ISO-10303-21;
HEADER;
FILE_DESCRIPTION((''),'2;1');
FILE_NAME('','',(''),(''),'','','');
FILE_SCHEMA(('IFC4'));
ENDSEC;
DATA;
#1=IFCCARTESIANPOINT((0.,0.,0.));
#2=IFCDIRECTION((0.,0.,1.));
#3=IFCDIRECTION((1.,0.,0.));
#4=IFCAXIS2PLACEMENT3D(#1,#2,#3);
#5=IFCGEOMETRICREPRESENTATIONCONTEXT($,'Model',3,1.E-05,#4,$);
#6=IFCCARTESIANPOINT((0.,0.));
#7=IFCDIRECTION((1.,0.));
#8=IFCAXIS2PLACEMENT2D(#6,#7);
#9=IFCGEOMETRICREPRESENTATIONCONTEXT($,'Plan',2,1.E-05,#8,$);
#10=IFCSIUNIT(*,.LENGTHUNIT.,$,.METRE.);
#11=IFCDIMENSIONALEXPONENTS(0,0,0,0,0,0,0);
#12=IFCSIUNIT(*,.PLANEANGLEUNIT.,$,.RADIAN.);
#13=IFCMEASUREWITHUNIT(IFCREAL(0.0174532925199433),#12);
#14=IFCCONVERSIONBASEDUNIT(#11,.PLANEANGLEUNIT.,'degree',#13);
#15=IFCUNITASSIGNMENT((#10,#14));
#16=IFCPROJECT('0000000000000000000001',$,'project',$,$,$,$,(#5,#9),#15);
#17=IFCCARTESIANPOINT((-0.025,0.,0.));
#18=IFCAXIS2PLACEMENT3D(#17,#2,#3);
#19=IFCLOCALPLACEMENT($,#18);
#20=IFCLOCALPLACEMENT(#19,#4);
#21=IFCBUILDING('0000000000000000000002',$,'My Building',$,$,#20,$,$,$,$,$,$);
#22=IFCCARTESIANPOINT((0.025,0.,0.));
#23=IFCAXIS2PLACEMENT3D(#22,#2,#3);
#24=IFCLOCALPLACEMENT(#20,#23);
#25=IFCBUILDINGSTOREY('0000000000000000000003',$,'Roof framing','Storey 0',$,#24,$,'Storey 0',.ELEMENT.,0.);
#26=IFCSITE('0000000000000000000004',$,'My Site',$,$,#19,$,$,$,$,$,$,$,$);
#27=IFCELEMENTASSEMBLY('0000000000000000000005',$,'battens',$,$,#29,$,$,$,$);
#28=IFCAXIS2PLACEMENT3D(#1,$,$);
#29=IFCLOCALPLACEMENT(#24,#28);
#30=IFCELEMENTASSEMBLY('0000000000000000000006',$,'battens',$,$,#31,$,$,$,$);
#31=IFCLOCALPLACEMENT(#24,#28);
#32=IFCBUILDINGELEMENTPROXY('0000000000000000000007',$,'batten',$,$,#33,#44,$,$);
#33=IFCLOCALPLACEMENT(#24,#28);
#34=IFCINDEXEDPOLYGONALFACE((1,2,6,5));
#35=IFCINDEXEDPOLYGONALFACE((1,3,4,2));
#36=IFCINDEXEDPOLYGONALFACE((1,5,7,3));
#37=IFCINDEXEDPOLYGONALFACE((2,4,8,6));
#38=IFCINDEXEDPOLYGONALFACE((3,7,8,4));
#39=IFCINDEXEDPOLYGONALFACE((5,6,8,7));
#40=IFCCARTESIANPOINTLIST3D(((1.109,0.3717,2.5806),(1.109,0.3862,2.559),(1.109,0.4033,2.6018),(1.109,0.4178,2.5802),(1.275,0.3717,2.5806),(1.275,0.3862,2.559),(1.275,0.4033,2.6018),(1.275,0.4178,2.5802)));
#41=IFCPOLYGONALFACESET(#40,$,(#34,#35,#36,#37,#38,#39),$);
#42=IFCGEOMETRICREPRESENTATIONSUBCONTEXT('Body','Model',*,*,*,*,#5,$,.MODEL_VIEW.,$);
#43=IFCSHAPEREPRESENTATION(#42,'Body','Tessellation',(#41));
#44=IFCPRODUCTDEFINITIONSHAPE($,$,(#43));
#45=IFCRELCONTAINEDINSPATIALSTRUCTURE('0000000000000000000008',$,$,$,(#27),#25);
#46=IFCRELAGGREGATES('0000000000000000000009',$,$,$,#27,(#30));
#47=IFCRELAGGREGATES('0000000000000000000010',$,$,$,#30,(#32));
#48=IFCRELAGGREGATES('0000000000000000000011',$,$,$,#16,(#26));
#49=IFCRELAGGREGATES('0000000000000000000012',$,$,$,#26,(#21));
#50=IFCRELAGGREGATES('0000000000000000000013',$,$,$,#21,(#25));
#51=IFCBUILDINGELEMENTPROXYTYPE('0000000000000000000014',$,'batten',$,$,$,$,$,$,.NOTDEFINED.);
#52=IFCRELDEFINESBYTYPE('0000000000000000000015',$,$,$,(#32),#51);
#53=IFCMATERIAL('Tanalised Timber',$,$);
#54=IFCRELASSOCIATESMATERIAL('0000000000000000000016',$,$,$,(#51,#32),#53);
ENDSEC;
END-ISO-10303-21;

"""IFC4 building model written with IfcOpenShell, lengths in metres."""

from ifc_helpers import new_model, entity, si_unit, converted_unit, frame, frame_2d, origin_with_axes, origin_2d_with_axis, place, context, subcontext, project, spatial, rectangle, extrude, material, material_profile, profile_set, profile_usage, type_object, element, aggregate, save


model = new_model("IFC4")

# Units and contexts
model_context = context("Model", 3, precision=1e-05, world=origin_with_axes())
plan_context = context("Plan", 2, precision=1e-05, world=origin_2d_with_axis())
body_context = subcontext(model_context, "Body", "Model", "MODEL_VIEW")
ifc_project = project(units=[si_unit("LENGTHUNIT", "METRE"), converted_unit("PLANEANGLEUNIT", "degree", entity("IfcReal", 0.0174532925199433), si_unit("PLANEANGLEUNIT", "RADIAN"), dimensions=[0, 0, 0, 0, 0, 0, 0])], contexts=[model_context, plan_context])

# Site, building, storey
site_placement = place(None, frame((-0.025, 0.0, 0.0), z_axis=(0.0, 0.0, 1.0), x_axis=(1.0, 0.0, 0.0)))
site = spatial("IfcSite", under=ifc_project, at=site_placement, Name="My Site")
building_placement = place(site_placement, origin_with_axes())
building = spatial("IfcBuilding", under=site, at=building_placement, Name="My Building")
storey_placement = place(building_placement, frame((0.025, 0.0, 0.0), z_axis=(0.0, 0.0, 1.0), x_axis=(1.0, 0.0, 0.0)))
storey = spatial("IfcBuildingStorey", under=building, at=storey_placement, Name="Roof framing", Description="Storey 0", LongName="Storey 0", CompositionType="ELEMENT", Elevation=0.0)

# Element assemblies, building element proxy
assembly_1_placement = place(storey_placement, origin_with_axes())
assembly_1 = element("IfcElementAssembly", 1, at=assembly_1_placement, inside=storey, Name="battens")
ifc_material_1 = material(Name="Tanalised Timber")
ifc_material_profile_1 = material_profile(ifc_material_1, rectangle(XDim=0.038, YDim=0.026, at=frame_2d((0.0, 0.083), x_axis=(1.0, 0.0))))
ifc_profile_set_1 = profile_set([ifc_material_profile_1])
building_element_proxy_type = type_object("IfcBuildingElementProxyType", Name="batten", PredefinedType="NOTDEFINED", material=ifc_profile_set_1)
assembly_2_placement = place(assembly_1_placement, frame((1.275, 0.275, 2.4), z_axis=(0.0, -0.557621, 0.830095), x_axis=(1.0, 0.0, 0.0)))
assembly_2 = element("IfcElementAssembly", 2, at=assembly_2_placement, Name="battens")
aggregate(assembly_1, [assembly_2])
ifc_profile_usage_1 = profile_usage(ifc_profile_set_1)
proxy_1_placement = place(assembly_2_placement, frame((0.0, 0.2, 0.0), z_axis=(-1.0, 0.0, 0.0), x_axis=(0.0, -1.0, 0.0)))
proxy_1 = element("IfcBuildingElementProxy", 3, at=proxy_1_placement, type_object=building_element_proxy_type, material=ifc_profile_usage_1, Name="batten", context=body_context, shape_type="SweptSolid", body=[
    extrude(rectangle(XDim=0.038, YDim=0.026, at=frame_2d((0.0, 0.083), x_axis=(1.0, 0.0))), origin_with_axes(), (0.0, 0.0, 1.0), 0.166),
])
aggregate(assembly_2, [proxy_1])

save(model, "model.ifc")
